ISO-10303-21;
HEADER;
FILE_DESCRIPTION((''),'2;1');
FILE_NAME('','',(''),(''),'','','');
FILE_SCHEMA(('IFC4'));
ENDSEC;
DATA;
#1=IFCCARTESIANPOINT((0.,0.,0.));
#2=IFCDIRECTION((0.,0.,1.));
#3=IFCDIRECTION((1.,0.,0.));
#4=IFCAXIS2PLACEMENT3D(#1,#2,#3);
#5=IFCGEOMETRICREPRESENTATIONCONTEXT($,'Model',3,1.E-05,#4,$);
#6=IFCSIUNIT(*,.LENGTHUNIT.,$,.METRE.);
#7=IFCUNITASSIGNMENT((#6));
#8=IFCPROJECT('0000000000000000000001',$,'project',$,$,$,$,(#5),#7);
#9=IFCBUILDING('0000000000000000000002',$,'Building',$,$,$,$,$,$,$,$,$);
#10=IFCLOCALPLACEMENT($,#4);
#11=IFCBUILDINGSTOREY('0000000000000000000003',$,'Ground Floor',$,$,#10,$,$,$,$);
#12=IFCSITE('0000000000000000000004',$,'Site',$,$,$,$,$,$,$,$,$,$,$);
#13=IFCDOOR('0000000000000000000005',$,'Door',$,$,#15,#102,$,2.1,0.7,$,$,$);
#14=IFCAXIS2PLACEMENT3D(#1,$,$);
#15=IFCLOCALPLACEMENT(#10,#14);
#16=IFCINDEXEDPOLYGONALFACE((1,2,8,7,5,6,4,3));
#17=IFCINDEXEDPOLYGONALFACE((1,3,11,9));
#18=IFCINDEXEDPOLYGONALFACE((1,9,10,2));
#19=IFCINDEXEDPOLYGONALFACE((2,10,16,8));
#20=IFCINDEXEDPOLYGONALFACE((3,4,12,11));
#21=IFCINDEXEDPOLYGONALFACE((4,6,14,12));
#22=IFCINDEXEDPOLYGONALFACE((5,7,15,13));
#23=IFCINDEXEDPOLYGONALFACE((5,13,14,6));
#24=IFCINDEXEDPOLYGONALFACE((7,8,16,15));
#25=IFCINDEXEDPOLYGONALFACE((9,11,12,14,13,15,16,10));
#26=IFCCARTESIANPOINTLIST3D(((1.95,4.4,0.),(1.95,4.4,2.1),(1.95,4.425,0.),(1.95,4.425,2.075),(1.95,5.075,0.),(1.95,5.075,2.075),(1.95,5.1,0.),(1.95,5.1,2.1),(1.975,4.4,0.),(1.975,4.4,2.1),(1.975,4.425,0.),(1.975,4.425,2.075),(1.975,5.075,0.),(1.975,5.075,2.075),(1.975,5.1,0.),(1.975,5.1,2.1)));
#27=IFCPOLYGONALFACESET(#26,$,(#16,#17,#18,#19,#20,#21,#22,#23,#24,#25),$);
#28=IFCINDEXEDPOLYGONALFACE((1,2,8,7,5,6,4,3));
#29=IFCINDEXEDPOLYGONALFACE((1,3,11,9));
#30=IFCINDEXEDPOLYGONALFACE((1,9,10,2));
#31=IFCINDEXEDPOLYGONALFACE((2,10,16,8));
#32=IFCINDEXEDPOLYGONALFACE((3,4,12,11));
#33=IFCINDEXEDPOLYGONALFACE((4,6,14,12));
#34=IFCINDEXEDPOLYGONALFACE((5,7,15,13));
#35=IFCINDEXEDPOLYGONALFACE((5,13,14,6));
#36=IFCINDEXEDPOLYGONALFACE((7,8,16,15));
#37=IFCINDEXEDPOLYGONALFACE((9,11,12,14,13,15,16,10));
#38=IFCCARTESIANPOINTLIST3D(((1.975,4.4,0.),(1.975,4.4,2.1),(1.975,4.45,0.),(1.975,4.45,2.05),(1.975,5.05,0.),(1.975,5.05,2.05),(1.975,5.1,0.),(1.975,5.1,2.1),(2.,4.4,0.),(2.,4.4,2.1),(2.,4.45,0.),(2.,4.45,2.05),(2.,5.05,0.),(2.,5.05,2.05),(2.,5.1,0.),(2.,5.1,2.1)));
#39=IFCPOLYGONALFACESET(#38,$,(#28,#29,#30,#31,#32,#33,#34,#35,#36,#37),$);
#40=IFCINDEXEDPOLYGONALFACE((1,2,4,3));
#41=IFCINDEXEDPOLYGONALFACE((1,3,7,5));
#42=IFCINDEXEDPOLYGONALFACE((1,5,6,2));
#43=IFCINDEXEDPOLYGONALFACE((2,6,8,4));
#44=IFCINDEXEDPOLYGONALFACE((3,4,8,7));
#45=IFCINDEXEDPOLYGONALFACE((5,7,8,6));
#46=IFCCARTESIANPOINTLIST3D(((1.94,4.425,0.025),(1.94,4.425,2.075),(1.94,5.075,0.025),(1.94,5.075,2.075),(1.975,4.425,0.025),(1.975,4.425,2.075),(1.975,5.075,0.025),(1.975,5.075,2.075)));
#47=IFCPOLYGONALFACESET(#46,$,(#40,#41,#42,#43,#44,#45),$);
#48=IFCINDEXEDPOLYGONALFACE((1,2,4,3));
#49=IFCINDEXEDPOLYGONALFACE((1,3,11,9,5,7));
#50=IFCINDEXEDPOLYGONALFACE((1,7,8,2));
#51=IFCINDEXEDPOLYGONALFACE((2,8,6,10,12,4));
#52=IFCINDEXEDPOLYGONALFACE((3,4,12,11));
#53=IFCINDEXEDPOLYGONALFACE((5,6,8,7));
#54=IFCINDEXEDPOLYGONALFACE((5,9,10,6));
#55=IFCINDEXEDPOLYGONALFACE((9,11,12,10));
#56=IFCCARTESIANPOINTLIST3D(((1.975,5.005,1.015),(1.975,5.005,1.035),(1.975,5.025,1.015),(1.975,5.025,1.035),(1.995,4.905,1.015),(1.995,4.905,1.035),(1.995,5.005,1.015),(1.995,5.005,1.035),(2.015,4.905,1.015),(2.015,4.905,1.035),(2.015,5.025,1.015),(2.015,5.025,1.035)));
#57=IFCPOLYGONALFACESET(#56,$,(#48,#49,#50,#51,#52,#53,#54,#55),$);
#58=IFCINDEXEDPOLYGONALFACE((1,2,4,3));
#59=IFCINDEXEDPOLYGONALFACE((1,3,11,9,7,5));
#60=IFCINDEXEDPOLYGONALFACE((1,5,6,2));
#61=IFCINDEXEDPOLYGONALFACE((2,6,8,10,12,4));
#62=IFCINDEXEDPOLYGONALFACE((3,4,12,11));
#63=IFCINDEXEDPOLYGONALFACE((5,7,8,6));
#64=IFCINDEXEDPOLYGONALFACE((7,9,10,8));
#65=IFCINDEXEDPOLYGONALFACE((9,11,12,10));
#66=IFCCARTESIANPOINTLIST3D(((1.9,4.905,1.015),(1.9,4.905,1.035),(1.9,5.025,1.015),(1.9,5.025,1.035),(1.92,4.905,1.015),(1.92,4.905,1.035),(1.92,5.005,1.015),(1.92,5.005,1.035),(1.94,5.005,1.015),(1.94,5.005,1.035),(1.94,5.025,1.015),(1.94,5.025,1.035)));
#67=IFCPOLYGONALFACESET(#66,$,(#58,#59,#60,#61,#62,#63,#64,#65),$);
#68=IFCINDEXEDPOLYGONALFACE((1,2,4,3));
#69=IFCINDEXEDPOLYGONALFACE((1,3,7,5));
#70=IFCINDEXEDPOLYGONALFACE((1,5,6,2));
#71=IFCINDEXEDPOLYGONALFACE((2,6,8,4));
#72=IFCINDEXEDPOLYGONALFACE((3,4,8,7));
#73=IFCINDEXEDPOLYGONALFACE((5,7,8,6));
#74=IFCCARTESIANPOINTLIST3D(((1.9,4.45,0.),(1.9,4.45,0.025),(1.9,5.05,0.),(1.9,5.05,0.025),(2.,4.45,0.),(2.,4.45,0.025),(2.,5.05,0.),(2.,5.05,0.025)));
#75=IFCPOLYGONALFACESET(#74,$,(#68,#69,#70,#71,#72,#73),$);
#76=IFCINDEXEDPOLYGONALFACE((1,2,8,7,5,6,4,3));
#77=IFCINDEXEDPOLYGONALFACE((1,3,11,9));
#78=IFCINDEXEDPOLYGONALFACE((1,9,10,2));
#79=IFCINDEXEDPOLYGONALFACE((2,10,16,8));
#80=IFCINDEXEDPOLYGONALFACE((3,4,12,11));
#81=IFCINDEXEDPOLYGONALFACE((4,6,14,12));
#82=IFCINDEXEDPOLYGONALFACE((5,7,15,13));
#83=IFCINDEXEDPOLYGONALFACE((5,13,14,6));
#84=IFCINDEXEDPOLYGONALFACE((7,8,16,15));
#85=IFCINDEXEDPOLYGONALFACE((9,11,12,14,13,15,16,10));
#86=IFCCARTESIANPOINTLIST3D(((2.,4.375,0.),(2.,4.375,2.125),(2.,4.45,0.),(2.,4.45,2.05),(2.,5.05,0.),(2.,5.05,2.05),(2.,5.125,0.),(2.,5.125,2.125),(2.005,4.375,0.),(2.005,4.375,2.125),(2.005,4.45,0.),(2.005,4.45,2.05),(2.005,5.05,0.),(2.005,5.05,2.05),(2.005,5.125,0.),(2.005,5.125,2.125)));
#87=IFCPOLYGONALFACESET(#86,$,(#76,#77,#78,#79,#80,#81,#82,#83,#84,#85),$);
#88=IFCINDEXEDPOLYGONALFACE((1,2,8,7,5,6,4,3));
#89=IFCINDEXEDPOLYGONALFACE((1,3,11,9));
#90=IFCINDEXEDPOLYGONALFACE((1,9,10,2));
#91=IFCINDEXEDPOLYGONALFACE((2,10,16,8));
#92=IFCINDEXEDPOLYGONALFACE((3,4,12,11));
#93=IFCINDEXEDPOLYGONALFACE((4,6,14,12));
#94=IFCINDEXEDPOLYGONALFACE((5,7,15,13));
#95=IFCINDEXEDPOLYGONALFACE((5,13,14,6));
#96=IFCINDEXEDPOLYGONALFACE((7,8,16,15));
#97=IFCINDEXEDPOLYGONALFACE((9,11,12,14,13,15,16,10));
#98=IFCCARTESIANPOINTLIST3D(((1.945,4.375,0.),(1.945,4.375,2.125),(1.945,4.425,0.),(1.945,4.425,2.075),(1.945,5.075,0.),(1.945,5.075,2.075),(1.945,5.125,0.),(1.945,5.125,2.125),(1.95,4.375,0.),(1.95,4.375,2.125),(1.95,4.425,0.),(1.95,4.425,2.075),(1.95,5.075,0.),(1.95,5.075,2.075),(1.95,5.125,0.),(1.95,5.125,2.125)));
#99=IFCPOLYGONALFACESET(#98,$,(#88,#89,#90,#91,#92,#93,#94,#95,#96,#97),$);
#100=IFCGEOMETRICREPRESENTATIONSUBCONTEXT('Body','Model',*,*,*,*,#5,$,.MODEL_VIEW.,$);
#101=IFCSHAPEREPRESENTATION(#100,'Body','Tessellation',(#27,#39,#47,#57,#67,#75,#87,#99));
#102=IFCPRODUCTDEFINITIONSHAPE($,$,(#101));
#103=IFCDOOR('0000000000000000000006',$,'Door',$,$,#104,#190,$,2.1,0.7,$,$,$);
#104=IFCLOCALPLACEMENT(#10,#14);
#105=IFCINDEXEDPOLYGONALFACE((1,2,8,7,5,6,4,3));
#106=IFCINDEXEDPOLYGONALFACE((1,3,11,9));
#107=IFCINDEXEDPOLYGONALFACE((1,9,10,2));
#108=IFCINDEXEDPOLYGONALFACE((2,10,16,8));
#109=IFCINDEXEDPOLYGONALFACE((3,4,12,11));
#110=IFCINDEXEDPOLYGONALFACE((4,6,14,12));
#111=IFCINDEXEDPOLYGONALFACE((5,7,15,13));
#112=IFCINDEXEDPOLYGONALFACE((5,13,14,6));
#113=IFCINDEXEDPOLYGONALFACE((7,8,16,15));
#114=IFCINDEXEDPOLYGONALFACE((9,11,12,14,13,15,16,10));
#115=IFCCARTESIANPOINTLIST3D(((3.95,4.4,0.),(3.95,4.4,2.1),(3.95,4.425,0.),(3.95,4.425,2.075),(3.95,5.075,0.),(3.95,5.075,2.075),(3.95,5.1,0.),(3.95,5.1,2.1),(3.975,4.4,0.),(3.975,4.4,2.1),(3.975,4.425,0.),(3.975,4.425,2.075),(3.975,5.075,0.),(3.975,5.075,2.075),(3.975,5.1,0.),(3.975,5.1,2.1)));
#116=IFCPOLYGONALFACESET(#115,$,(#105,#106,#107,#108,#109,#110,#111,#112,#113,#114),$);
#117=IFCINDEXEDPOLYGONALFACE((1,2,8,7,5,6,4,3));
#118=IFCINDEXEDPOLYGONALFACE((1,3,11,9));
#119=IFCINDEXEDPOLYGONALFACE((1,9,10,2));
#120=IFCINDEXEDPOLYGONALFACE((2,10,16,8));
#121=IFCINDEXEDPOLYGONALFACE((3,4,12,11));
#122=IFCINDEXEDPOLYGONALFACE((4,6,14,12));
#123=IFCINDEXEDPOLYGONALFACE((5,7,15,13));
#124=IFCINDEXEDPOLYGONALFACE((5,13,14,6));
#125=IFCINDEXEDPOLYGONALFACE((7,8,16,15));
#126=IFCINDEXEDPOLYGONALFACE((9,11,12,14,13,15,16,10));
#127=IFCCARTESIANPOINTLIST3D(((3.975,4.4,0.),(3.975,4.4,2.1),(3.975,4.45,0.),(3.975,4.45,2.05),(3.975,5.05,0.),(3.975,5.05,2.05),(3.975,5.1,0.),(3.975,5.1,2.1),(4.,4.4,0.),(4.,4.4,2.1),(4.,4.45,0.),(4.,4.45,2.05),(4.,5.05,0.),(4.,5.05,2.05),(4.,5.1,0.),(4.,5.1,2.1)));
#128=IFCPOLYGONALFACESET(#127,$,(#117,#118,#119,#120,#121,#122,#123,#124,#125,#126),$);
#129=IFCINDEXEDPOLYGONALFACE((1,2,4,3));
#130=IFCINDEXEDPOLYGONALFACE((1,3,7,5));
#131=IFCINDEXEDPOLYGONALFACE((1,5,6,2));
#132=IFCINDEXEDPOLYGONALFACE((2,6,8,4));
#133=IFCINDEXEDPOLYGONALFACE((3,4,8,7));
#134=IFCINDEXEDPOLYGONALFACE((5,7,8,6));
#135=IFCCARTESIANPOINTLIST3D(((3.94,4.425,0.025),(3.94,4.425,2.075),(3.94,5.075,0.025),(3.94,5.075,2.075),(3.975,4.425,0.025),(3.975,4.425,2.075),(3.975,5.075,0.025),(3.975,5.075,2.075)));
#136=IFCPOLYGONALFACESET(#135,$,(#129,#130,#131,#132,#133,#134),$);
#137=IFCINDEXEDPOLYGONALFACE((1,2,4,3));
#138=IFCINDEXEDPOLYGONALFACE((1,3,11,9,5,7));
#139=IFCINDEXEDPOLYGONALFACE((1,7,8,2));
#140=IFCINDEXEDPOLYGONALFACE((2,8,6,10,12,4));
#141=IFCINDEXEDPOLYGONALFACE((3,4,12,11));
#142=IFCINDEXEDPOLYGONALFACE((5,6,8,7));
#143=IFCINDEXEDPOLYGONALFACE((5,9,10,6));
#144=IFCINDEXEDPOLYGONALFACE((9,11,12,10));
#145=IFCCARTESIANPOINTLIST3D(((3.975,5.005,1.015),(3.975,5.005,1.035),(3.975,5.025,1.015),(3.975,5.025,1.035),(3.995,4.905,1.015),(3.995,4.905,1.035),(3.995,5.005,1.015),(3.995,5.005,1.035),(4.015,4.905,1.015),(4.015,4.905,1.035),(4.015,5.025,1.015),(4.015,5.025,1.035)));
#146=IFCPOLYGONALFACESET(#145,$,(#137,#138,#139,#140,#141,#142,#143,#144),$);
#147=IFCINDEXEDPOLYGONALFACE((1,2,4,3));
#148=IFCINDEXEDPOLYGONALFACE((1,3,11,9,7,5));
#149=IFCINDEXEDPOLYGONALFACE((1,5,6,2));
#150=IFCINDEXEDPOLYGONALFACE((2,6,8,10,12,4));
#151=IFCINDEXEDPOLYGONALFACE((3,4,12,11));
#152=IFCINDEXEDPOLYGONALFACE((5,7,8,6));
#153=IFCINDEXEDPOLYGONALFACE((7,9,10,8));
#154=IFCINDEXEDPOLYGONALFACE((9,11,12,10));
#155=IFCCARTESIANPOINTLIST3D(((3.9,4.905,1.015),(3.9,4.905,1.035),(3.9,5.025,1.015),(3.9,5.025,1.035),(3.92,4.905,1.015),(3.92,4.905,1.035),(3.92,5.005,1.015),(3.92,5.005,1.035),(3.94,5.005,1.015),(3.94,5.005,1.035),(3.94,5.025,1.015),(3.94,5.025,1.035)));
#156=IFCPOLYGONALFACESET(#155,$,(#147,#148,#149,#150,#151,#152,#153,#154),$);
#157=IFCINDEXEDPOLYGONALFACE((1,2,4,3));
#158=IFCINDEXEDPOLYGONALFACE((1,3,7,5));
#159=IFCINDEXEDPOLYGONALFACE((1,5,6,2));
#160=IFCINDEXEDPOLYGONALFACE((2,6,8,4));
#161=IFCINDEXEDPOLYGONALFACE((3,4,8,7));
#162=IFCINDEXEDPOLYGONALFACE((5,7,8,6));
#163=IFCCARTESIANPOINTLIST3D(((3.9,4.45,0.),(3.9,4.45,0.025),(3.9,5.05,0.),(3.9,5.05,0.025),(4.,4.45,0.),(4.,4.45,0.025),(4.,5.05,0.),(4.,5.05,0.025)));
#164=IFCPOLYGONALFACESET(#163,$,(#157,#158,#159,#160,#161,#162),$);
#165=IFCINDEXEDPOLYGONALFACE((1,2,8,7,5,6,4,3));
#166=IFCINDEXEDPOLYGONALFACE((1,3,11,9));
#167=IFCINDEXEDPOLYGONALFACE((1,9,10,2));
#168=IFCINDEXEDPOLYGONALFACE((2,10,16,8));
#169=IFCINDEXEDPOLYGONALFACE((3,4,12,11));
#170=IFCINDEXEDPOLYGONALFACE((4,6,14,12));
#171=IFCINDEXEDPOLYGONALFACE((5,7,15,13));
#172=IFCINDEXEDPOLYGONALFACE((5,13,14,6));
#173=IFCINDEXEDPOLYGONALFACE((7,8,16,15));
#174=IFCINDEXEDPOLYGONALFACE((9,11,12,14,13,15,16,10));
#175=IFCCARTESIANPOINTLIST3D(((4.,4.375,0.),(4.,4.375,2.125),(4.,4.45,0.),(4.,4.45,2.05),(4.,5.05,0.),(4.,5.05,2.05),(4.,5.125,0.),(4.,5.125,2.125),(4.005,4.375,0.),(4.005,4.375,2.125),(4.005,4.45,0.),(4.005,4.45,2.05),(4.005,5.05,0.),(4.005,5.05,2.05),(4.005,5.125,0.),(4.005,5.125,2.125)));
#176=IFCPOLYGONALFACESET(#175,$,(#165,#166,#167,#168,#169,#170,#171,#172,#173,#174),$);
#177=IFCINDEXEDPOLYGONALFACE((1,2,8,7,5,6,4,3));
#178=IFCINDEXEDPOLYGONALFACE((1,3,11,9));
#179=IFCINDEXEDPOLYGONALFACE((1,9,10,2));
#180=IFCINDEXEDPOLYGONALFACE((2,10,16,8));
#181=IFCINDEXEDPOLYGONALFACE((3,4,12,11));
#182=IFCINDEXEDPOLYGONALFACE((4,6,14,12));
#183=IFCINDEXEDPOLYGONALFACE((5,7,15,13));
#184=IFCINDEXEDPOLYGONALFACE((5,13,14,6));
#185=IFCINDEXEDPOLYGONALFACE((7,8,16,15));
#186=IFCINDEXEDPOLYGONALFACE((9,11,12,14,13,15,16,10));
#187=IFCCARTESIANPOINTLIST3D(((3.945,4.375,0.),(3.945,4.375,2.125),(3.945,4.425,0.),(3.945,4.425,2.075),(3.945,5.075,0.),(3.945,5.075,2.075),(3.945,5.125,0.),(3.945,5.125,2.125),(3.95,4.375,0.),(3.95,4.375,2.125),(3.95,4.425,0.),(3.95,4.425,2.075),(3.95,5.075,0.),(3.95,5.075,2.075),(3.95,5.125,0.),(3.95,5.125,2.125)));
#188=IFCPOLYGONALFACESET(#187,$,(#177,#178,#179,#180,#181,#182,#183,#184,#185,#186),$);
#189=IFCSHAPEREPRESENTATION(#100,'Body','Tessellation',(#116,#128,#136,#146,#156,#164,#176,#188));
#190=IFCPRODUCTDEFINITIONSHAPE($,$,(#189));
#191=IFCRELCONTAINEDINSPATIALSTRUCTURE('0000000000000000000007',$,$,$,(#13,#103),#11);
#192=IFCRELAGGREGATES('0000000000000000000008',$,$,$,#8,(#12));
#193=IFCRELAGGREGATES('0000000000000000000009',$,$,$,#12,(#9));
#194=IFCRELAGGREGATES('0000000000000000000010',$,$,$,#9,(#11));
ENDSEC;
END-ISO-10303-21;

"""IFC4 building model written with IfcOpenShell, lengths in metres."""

from ifc_helpers import new_model, si_unit, frame, origin_with_axes, place, context, subcontext, project, spatial, line, indexed_curve, outline, extrude, element, save


model = new_model("IFC4")

# Units and contexts
model_context = context("Model", 3, precision=1e-05, world=origin_with_axes())
body_context = subcontext(model_context, "Body", "Model", "MODEL_VIEW")
ifc_project = project(units=[si_unit("LENGTHUNIT", "METRE")], contexts=[model_context])

# Site, building, storey
site = spatial("IfcSite", under=ifc_project, Name="Site")
building = spatial("IfcBuilding", under=site, Name="Building")
storey_placement = place(None, origin_with_axes())
storey = spatial("IfcBuildingStorey", under=building, at=storey_placement, Name="Ground Floor")

# Doors
door_1_placement = place(storey_placement, frame((2.0, 4.4, 0.0), z_axis=(0.0, 0.0, 1.0), x_axis=(0.0, 1.0, 0.0)))
element("IfcDoor", 1, at=door_1_placement, inside=storey, Name="Door", OverallHeight=2.1, OverallWidth=0.7, context=body_context, shape_type="SweptSolid", body=[
    extrude(outline(indexed_curve([(0.0, 0.0), (0.0, 2.1), (0.7, 2.1), (0.7, 0.0), (0.675, 0.0), (0.675, 2.075), (0.025, 2.075), (0.025, 0.0)], segments=[line(1, 2, 3, 4, 5, 6, 7, 8, 1)])), frame((0.0, 0.025, 0.0), z_axis=(0.0, -1.0, 0.0), x_axis=(1.0, 0.0, 0.0)), (0.0, 0.0, -1.0), 0.025),
    extrude(outline(indexed_curve([(0.0, 0.0), (0.0, 2.1), (0.7, 2.1), (0.7, 0.0), (0.65, 0.0), (0.65, 2.05), (0.05, 2.05), (0.05, 0.0)], segments=[line(1, 2, 3, 4, 5, 6, 7, 8, 1)])), frame((0.0, 0.0, 0.0), z_axis=(0.0, -1.0, 0.0), x_axis=(1.0, 0.0, 0.0)), (0.0, 0.0, -1.0), 0.025),
    extrude(outline(indexed_curve([(0.0, 0.0), (0.65, 0.0), (0.65, 0.035), (0.0, 0.035)], segments=[line(1, 2, 3, 4, 1)])), frame((0.025, 0.025, 0.025), z_axis=(0.0, 0.0, 1.0), x_axis=(1.0, 0.0, 0.0)), (0.0, 0.0, 1.0), 2.05),
    extrude(outline(indexed_curve([(0.0, 0.0), (0.0, -0.04), (-0.12, -0.04), (-0.12, -0.02), (-0.02, -0.02), (-0.02, 0.0)], segments=[line(1, 2, 3, 4, 5, 6, 1)])), frame((0.625, 0.025, 1.015), z_axis=(0.0, 0.0, 1.0), x_axis=(1.0, 0.0, 0.0)), (0.0, 0.0, 1.0), 0.02),
    extrude(outline(indexed_curve([(0.0, 0.0), (0.0, 0.04), (-0.12, 0.04), (-0.12, 0.02), (-0.02, 0.02), (-0.02, 0.0)], segments=[line(1, 2, 3, 4, 5, 6, 1)])), frame((0.625, 0.06, 1.015), z_axis=(0.0, 0.0, 1.0), x_axis=(1.0, 0.0, 0.0)), (0.0, 0.0, 1.0), 0.02),
    extrude(outline(indexed_curve([(0.0, 0.0), (0.6, 0.0), (0.6, 0.1), (0.0, 0.1)], segments=[line(1, 2, 3, 4, 1)])), frame((0.05, 0.0, 0.0), z_axis=(0.0, 0.0, 1.0), x_axis=(1.0, 0.0, 0.0)), (0.0, 0.0, 1.0), 0.025),
    extrude(outline(indexed_curve([(0.0, 0.0), (0.0, 2.125), (0.75, 2.125), (0.75, 0.0), (0.675, 0.0), (0.675, 2.05), (0.075, 2.05), (0.075, 0.0)], segments=[line(1, 2, 3, 4, 5, 6, 7, 8, 1)])), frame((-0.025, -0.005, 0.0), z_axis=(0.0, -1.0, 0.0), x_axis=(1.0, 0.0, 0.0)), (0.0, 0.0, -1.0), 0.005),
    extrude(outline(indexed_curve([(0.0, 0.0), (0.0, 2.125), (0.75, 2.125), (0.75, 0.0), (0.7, 0.0), (0.7, 2.075), (0.05, 2.075), (0.05, 0.0)], segments=[line(1, 2, 3, 4, 5, 6, 7, 8, 1)])), frame((-0.025, 0.05, 0.0), z_axis=(0.0, -1.0, 0.0), x_axis=(1.0, 0.0, 0.0)), (0.0, 0.0, -1.0), 0.005),
])
door_2_placement = place(storey_placement, frame((4.0, 4.4, 0.0), z_axis=(0.0, 0.0, 1.0), x_axis=(0.0, 1.0, 0.0)))
element("IfcDoor", 2, at=door_2_placement, inside=storey, Name="Door", OverallHeight=2.1, OverallWidth=0.7, context=body_context, shape_type="SweptSolid", body=[
    extrude(outline(indexed_curve([(0.0, 0.0), (0.0, 2.1), (0.7, 2.1), (0.7, 0.0), (0.675, 0.0), (0.675, 2.075), (0.025, 2.075), (0.025, 0.0)], segments=[line(1, 2, 3, 4, 5, 6, 7, 8, 1)])), frame((0.0, 0.025, 0.0), z_axis=(0.0, -1.0, 0.0), x_axis=(1.0, 0.0, 0.0)), (0.0, 0.0, -1.0), 0.025),
    extrude(outline(indexed_curve([(0.0, 0.0), (0.0, 2.1), (0.7, 2.1), (0.7, 0.0), (0.65, 0.0), (0.65, 2.05), (0.05, 2.05), (0.05, 0.0)], segments=[line(1, 2, 3, 4, 5, 6, 7, 8, 1)])), frame((0.0, 0.0, 0.0), z_axis=(0.0, -1.0, 0.0), x_axis=(1.0, 0.0, 0.0)), (0.0, 0.0, -1.0), 0.025),
    extrude(outline(indexed_curve([(0.0, 0.0), (0.65, 0.0), (0.65, 0.035), (0.0, 0.035)], segments=[line(1, 2, 3, 4, 1)])), frame((0.025, 0.025, 0.025), z_axis=(0.0, 0.0, 1.0), x_axis=(1.0, 0.0, 0.0)), (0.0, 0.0, 1.0), 2.05),
    extrude(outline(indexed_curve([(0.0, 0.0), (0.0, -0.04), (-0.12, -0.04), (-0.12, -0.02), (-0.02, -0.02), (-0.02, 0.0)], segments=[line(1, 2, 3, 4, 5, 6, 1)])), frame((0.625, 0.025, 1.015), z_axis=(0.0, 0.0, 1.0), x_axis=(1.0, 0.0, 0.0)), (0.0, 0.0, 1.0), 0.02),
    extrude(outline(indexed_curve([(0.0, 0.0), (0.0, 0.04), (-0.12, 0.04), (-0.12, 0.02), (-0.02, 0.02), (-0.02, 0.0)], segments=[line(1, 2, 3, 4, 5, 6, 1)])), frame((0.625, 0.06, 1.015), z_axis=(0.0, 0.0, 1.0), x_axis=(1.0, 0.0, 0.0)), (0.0, 0.0, 1.0), 0.02),
    extrude(outline(indexed_curve([(0.0, 0.0), (0.6, 0.0), (0.6, 0.1), (0.0, 0.1)], segments=[line(1, 2, 3, 4, 1)])), frame((0.05, 0.0, 0.0), z_axis=(0.0, 0.0, 1.0), x_axis=(1.0, 0.0, 0.0)), (0.0, 0.0, 1.0), 0.025),
    extrude(outline(indexed_curve([(0.0, 0.0), (0.0, 2.125), (0.75, 2.125), (0.75, 0.0), (0.675, 0.0), (0.675, 2.05), (0.075, 2.05), (0.075, 0.0)], segments=[line(1, 2, 3, 4, 5, 6, 7, 8, 1)])), frame((-0.025, -0.005, 0.0), z_axis=(0.0, -1.0, 0.0), x_axis=(1.0, 0.0, 0.0)), (0.0, 0.0, -1.0), 0.005),
    extrude(outline(indexed_curve([(0.0, 0.0), (0.0, 2.125), (0.75, 2.125), (0.75, 0.0), (0.7, 0.0), (0.7, 2.075), (0.05, 2.075), (0.05, 0.0)], segments=[line(1, 2, 3, 4, 5, 6, 7, 8, 1)])), frame((-0.025, 0.05, 0.0), z_axis=(0.0, -1.0, 0.0), x_axis=(1.0, 0.0, 0.0)), (0.0, 0.0, -1.0), 0.005),
])

save(model, "model.ifc")
